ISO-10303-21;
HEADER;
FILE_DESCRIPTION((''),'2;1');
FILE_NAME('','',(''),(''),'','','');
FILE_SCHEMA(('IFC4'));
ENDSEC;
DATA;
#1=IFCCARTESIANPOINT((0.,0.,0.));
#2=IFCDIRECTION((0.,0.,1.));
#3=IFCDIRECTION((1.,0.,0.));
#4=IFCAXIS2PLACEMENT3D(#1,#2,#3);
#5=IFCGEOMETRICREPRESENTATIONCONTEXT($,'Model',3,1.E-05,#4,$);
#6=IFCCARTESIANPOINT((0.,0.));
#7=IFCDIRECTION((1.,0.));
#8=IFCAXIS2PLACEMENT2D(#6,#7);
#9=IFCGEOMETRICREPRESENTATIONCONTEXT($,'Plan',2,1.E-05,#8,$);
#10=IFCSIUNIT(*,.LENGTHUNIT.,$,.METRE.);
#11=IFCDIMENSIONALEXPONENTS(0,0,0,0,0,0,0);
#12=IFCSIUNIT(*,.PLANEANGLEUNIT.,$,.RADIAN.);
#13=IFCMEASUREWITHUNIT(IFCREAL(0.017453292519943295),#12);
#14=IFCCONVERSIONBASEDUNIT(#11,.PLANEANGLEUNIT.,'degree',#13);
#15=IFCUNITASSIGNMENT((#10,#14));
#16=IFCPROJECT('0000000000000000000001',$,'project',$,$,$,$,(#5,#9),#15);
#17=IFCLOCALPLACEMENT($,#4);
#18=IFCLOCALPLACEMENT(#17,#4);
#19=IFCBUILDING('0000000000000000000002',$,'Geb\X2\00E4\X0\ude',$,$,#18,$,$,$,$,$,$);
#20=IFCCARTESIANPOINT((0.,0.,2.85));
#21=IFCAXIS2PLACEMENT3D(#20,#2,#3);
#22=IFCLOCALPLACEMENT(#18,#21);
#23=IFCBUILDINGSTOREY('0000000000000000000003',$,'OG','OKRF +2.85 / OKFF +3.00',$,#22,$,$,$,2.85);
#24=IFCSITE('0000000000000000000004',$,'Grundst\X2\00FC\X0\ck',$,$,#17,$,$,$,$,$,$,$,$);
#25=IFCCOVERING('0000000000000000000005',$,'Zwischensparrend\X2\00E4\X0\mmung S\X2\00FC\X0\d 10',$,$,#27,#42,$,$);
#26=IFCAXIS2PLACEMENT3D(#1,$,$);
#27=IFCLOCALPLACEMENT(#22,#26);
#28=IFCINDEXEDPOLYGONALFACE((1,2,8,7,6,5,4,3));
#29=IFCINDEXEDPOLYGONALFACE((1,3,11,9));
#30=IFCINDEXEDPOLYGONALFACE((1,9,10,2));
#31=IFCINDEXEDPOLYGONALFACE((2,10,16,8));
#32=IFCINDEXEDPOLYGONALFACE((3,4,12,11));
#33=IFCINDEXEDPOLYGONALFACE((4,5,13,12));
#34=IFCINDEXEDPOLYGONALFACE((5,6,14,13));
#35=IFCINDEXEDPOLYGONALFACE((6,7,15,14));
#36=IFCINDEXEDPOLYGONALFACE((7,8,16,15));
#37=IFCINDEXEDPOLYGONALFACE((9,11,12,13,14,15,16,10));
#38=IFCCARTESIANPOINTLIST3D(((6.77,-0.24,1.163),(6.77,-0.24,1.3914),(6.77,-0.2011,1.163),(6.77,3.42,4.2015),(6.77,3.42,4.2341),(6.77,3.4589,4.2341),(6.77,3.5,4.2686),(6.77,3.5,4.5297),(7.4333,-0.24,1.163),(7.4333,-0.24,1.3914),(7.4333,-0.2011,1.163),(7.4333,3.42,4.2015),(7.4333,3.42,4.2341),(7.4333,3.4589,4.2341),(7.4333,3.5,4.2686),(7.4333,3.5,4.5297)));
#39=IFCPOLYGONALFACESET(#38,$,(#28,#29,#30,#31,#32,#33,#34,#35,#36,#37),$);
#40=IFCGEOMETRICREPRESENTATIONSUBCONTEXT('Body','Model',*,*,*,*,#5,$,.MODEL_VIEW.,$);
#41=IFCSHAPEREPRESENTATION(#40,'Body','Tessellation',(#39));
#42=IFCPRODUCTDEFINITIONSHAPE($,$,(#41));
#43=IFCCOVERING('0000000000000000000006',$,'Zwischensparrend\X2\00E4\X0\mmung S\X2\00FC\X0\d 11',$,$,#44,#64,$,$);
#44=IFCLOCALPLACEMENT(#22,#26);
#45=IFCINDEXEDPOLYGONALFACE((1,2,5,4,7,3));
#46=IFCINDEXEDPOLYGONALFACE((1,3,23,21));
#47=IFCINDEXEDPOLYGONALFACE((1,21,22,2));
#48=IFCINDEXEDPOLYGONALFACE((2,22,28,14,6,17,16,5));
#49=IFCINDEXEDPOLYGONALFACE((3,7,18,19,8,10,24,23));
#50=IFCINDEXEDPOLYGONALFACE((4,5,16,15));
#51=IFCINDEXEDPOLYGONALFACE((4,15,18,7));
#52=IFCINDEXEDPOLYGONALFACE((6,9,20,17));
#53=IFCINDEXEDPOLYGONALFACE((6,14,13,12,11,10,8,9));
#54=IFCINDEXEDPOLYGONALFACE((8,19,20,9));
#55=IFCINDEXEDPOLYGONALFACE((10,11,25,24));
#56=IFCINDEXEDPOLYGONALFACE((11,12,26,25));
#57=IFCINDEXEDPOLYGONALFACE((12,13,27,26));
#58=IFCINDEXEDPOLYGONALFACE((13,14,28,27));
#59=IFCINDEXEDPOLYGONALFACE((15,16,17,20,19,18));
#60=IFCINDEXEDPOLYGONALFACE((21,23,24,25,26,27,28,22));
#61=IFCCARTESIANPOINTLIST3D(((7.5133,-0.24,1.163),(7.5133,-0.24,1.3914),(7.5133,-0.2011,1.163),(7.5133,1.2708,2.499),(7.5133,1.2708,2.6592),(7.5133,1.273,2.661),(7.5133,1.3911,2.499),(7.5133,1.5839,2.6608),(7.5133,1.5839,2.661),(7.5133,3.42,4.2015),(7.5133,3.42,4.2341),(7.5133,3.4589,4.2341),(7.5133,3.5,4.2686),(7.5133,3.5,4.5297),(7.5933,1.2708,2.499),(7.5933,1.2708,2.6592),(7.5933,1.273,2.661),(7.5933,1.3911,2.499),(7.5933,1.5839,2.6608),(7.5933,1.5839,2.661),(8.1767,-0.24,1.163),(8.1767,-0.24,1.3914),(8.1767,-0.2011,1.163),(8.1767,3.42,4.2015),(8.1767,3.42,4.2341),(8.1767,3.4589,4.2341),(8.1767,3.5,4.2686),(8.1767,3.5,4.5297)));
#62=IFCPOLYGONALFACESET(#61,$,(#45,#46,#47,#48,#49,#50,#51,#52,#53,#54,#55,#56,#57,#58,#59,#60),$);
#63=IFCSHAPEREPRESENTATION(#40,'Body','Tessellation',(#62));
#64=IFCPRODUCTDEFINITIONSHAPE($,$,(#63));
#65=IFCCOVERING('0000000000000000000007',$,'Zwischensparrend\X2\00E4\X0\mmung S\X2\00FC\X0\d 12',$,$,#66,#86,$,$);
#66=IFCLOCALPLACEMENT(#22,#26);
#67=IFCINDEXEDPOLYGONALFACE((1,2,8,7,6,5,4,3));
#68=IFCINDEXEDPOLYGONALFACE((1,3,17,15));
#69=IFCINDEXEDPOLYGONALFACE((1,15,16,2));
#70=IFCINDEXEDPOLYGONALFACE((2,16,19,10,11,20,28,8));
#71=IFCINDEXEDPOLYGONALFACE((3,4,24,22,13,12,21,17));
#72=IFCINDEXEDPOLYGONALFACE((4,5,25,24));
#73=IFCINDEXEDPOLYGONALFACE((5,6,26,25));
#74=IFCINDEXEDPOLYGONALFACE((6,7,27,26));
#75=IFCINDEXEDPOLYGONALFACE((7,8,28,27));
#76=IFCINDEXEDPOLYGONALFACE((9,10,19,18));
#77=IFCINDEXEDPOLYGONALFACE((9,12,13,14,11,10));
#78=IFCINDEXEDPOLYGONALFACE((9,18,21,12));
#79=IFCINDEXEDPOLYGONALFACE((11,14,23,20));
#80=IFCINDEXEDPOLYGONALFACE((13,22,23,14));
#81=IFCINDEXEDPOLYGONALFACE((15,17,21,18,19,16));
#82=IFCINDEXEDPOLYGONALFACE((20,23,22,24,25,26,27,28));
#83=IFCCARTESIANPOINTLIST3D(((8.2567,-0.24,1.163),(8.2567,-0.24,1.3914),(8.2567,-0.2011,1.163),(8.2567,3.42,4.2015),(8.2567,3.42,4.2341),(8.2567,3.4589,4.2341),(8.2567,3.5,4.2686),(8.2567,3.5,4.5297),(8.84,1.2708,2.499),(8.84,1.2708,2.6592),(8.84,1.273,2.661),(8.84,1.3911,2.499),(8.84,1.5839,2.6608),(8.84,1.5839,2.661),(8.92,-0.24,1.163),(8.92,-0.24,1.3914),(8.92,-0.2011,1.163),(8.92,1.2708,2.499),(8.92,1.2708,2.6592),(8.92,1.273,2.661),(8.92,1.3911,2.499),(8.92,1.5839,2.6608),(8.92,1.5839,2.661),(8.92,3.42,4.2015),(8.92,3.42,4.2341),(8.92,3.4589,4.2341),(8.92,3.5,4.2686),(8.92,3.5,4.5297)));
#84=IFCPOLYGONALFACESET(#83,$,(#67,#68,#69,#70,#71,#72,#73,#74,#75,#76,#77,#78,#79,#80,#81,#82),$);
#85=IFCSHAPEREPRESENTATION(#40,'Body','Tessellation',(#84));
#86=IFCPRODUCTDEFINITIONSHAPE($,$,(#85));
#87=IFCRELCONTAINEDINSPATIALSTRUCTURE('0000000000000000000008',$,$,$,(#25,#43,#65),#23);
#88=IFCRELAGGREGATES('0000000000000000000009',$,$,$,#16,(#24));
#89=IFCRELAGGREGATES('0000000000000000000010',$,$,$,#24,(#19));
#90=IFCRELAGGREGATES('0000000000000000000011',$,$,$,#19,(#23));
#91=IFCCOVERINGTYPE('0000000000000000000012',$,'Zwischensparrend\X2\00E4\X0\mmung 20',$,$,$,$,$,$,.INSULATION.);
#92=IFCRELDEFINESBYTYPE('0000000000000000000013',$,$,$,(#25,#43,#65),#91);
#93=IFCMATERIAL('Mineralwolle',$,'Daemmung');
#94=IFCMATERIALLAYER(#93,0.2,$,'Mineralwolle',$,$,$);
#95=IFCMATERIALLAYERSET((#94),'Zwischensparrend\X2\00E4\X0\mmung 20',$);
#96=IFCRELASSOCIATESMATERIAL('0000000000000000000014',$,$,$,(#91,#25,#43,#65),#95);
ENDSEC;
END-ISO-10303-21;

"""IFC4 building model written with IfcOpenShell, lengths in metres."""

from ifc_helpers import new_model, entity, si_unit, converted_unit, frame, origin_with_axes, origin_2d_with_axis, place, context, subcontext, project, spatial, polyline, outline, extrude, material, layer, layer_set, layer_usage, type_object, element, save


model = new_model("IFC4")

# Units and contexts
model_context = context("Model", 3, precision=1e-05, world=origin_with_axes())
plan_context = context("Plan", 2, precision=1e-05, world=origin_2d_with_axis())
body_context = subcontext(model_context, "Body", "Model", "MODEL_VIEW")
ifc_project = project(units=[si_unit("LENGTHUNIT", "METRE"), converted_unit("PLANEANGLEUNIT", "degree", entity("IfcReal", 0.017453292519943295), si_unit("PLANEANGLEUNIT", "RADIAN"), dimensions=[0, 0, 0, 0, 0, 0, 0])], contexts=[model_context, plan_context])

# Site, building, storey
site_placement = place(None, origin_with_axes())
site = spatial("IfcSite", under=ifc_project, at=site_placement, Name="Grundstück")
building_placement = place(site_placement, origin_with_axes())
building = spatial("IfcBuilding", under=site, at=building_placement, Name="Gebäude")
storey_placement = place(building_placement, frame((0.0, 0.0, 2.85), z_axis=(0.0, 0.0, 1.0), x_axis=(1.0, 0.0, 0.0)))
storey = spatial("IfcBuildingStorey", under=building, at=storey_placement, Name="OG", Description="OKRF +2.85 / OKFF +3.00", Elevation=2.85)

# Covering
ifc_material_1 = material(Name="Mineralwolle", Category="Daemmung")
ifc_layer = layer(ifc_material_1, 0.2, Name="Mineralwolle")
ifc_layer_set = layer_set([ifc_layer], Name="Zwischensparrendämmung 20")
ifc_layer_usage_1 = layer_usage(ifc_layer_set, "AXIS3", "POSITIVE", 0.0)
covering_type = type_object("IfcCoveringType", Name="Zwischensparrendämmung 20", PredefinedType="INSULATION", material=ifc_layer_set)
covering_1_placement = place(storey_placement, frame((6.77, -0.24, 1.1304), z_axis=(0.0, -0.642788, 0.766044), x_axis=(1.0, 0.0, 0.0)))
element("IfcCovering", 1, at=covering_1_placement, inside=storey, type_object=covering_type, material=ifc_layer_usage_1, Name="Zwischensparrendämmung Süd 10", context=body_context, shape_type="SweptSolid", body=[
    extrude(outline(polyline([(0.021, 0.025), (0.0508, 0.0), (4.7778, 0.0), (4.7988, 0.025), (4.8286, 0.0), (4.8822, 0.0), (5.05, 0.2), (0.1678, 0.2), (0.021, 0.025)])), frame((0.0, 0.0, 0.0), z_axis=(1.0, 0.0, 0.0), x_axis=(0.0, 1.0, 0.0)), (0.0, 0.0, 1.0), 0.6633),
])

# Coverings, openings
ifc_layer_usage_2 = layer_usage(ifc_layer_set, "AXIS3", "POSITIVE", 0.0)
covering_2_placement = place(storey_placement, frame((7.5133, -0.24, 1.1304), z_axis=(0.0, -0.642788, 0.766044), x_axis=(1.0, 0.0, 0.0)))
covering_2 = element("IfcCovering", 2, at=covering_2_placement, inside=storey, type_object=covering_type, material=ifc_layer_usage_2, Name="Zwischensparrendämmung Süd 11", context=body_context, shape_type="SweptSolid", body=[
    extrude(outline(polyline([(0.021, 0.025), (0.0508, 0.0), (4.7778, 0.0), (4.7988, 0.025), (4.8286, 0.0), (4.8822, 0.0), (5.05, 0.2), (0.1678, 0.2), (0.021, 0.025)])), frame((0.0, 0.0, 0.0), z_axis=(1.0, 0.0, 0.0), x_axis=(0.0, 1.0, 0.0)), (0.0, 0.0, 1.0), 0.6633),
])
opening_1_placement = place(covering_2_placement, frame((-7.5133, -2.3747, -3.2034), z_axis=(0.0, 0.642788, 0.766044), x_axis=(1.0, 0.0, 0.0)))
element("IfcOpeningElement", 3, at=opening_1_placement, cuts=covering_2, PredefinedType="RECESS", context=body_context, shape_type="SweptSolid", body=[
    extrude(outline(polyline([(7.5133, 1.2708), (7.5933, 1.2708), (7.5933, 1.5839), (7.5133, 1.5839), (7.5133, 1.2708)])), frame((0.0, 0.0, 5.349), z_axis=(0.0, 0.0, 1.0), x_axis=(1.0, 0.0, 0.0)), (0.0, 0.0, 1.0), 0.162),
])
ifc_layer_usage_3 = layer_usage(ifc_layer_set, "AXIS3", "POSITIVE", 0.0)
covering_3_placement = place(storey_placement, frame((8.2567, -0.24, 1.1304), z_axis=(0.0, -0.642788, 0.766044), x_axis=(1.0, 0.0, 0.0)))
covering_3 = element("IfcCovering", 4, at=covering_3_placement, inside=storey, type_object=covering_type, material=ifc_layer_usage_3, Name="Zwischensparrendämmung Süd 12", context=body_context, shape_type="SweptSolid", body=[
    extrude(outline(polyline([(0.021, 0.025), (0.0508, 0.0), (4.7778, 0.0), (4.7988, 0.025), (4.8286, 0.0), (4.8822, 0.0), (5.05, 0.2), (0.1678, 0.2), (0.021, 0.025)])), frame((0.0, 0.0, 0.0), z_axis=(1.0, 0.0, 0.0), x_axis=(0.0, 1.0, 0.0)), (0.0, 0.0, 1.0), 0.6633),
])
opening_2_placement = place(covering_3_placement, frame((-8.2567, -2.3747, -3.2034), z_axis=(0.0, 0.642788, 0.766044), x_axis=(1.0, 0.0, 0.0)))
element("IfcOpeningElement", 5, at=opening_2_placement, cuts=covering_3, PredefinedType="RECESS", context=body_context, shape_type="SweptSolid", body=[
    extrude(outline(polyline([(8.84, 1.2708), (8.92, 1.2708), (8.92, 1.5839), (8.84, 1.5839), (8.84, 1.2708)])), frame((0.0, 0.0, 5.349), z_axis=(0.0, 0.0, 1.0), x_axis=(1.0, 0.0, 0.0)), (0.0, 0.0, 1.0), 0.162),
])

save(model, "model.ifc")
